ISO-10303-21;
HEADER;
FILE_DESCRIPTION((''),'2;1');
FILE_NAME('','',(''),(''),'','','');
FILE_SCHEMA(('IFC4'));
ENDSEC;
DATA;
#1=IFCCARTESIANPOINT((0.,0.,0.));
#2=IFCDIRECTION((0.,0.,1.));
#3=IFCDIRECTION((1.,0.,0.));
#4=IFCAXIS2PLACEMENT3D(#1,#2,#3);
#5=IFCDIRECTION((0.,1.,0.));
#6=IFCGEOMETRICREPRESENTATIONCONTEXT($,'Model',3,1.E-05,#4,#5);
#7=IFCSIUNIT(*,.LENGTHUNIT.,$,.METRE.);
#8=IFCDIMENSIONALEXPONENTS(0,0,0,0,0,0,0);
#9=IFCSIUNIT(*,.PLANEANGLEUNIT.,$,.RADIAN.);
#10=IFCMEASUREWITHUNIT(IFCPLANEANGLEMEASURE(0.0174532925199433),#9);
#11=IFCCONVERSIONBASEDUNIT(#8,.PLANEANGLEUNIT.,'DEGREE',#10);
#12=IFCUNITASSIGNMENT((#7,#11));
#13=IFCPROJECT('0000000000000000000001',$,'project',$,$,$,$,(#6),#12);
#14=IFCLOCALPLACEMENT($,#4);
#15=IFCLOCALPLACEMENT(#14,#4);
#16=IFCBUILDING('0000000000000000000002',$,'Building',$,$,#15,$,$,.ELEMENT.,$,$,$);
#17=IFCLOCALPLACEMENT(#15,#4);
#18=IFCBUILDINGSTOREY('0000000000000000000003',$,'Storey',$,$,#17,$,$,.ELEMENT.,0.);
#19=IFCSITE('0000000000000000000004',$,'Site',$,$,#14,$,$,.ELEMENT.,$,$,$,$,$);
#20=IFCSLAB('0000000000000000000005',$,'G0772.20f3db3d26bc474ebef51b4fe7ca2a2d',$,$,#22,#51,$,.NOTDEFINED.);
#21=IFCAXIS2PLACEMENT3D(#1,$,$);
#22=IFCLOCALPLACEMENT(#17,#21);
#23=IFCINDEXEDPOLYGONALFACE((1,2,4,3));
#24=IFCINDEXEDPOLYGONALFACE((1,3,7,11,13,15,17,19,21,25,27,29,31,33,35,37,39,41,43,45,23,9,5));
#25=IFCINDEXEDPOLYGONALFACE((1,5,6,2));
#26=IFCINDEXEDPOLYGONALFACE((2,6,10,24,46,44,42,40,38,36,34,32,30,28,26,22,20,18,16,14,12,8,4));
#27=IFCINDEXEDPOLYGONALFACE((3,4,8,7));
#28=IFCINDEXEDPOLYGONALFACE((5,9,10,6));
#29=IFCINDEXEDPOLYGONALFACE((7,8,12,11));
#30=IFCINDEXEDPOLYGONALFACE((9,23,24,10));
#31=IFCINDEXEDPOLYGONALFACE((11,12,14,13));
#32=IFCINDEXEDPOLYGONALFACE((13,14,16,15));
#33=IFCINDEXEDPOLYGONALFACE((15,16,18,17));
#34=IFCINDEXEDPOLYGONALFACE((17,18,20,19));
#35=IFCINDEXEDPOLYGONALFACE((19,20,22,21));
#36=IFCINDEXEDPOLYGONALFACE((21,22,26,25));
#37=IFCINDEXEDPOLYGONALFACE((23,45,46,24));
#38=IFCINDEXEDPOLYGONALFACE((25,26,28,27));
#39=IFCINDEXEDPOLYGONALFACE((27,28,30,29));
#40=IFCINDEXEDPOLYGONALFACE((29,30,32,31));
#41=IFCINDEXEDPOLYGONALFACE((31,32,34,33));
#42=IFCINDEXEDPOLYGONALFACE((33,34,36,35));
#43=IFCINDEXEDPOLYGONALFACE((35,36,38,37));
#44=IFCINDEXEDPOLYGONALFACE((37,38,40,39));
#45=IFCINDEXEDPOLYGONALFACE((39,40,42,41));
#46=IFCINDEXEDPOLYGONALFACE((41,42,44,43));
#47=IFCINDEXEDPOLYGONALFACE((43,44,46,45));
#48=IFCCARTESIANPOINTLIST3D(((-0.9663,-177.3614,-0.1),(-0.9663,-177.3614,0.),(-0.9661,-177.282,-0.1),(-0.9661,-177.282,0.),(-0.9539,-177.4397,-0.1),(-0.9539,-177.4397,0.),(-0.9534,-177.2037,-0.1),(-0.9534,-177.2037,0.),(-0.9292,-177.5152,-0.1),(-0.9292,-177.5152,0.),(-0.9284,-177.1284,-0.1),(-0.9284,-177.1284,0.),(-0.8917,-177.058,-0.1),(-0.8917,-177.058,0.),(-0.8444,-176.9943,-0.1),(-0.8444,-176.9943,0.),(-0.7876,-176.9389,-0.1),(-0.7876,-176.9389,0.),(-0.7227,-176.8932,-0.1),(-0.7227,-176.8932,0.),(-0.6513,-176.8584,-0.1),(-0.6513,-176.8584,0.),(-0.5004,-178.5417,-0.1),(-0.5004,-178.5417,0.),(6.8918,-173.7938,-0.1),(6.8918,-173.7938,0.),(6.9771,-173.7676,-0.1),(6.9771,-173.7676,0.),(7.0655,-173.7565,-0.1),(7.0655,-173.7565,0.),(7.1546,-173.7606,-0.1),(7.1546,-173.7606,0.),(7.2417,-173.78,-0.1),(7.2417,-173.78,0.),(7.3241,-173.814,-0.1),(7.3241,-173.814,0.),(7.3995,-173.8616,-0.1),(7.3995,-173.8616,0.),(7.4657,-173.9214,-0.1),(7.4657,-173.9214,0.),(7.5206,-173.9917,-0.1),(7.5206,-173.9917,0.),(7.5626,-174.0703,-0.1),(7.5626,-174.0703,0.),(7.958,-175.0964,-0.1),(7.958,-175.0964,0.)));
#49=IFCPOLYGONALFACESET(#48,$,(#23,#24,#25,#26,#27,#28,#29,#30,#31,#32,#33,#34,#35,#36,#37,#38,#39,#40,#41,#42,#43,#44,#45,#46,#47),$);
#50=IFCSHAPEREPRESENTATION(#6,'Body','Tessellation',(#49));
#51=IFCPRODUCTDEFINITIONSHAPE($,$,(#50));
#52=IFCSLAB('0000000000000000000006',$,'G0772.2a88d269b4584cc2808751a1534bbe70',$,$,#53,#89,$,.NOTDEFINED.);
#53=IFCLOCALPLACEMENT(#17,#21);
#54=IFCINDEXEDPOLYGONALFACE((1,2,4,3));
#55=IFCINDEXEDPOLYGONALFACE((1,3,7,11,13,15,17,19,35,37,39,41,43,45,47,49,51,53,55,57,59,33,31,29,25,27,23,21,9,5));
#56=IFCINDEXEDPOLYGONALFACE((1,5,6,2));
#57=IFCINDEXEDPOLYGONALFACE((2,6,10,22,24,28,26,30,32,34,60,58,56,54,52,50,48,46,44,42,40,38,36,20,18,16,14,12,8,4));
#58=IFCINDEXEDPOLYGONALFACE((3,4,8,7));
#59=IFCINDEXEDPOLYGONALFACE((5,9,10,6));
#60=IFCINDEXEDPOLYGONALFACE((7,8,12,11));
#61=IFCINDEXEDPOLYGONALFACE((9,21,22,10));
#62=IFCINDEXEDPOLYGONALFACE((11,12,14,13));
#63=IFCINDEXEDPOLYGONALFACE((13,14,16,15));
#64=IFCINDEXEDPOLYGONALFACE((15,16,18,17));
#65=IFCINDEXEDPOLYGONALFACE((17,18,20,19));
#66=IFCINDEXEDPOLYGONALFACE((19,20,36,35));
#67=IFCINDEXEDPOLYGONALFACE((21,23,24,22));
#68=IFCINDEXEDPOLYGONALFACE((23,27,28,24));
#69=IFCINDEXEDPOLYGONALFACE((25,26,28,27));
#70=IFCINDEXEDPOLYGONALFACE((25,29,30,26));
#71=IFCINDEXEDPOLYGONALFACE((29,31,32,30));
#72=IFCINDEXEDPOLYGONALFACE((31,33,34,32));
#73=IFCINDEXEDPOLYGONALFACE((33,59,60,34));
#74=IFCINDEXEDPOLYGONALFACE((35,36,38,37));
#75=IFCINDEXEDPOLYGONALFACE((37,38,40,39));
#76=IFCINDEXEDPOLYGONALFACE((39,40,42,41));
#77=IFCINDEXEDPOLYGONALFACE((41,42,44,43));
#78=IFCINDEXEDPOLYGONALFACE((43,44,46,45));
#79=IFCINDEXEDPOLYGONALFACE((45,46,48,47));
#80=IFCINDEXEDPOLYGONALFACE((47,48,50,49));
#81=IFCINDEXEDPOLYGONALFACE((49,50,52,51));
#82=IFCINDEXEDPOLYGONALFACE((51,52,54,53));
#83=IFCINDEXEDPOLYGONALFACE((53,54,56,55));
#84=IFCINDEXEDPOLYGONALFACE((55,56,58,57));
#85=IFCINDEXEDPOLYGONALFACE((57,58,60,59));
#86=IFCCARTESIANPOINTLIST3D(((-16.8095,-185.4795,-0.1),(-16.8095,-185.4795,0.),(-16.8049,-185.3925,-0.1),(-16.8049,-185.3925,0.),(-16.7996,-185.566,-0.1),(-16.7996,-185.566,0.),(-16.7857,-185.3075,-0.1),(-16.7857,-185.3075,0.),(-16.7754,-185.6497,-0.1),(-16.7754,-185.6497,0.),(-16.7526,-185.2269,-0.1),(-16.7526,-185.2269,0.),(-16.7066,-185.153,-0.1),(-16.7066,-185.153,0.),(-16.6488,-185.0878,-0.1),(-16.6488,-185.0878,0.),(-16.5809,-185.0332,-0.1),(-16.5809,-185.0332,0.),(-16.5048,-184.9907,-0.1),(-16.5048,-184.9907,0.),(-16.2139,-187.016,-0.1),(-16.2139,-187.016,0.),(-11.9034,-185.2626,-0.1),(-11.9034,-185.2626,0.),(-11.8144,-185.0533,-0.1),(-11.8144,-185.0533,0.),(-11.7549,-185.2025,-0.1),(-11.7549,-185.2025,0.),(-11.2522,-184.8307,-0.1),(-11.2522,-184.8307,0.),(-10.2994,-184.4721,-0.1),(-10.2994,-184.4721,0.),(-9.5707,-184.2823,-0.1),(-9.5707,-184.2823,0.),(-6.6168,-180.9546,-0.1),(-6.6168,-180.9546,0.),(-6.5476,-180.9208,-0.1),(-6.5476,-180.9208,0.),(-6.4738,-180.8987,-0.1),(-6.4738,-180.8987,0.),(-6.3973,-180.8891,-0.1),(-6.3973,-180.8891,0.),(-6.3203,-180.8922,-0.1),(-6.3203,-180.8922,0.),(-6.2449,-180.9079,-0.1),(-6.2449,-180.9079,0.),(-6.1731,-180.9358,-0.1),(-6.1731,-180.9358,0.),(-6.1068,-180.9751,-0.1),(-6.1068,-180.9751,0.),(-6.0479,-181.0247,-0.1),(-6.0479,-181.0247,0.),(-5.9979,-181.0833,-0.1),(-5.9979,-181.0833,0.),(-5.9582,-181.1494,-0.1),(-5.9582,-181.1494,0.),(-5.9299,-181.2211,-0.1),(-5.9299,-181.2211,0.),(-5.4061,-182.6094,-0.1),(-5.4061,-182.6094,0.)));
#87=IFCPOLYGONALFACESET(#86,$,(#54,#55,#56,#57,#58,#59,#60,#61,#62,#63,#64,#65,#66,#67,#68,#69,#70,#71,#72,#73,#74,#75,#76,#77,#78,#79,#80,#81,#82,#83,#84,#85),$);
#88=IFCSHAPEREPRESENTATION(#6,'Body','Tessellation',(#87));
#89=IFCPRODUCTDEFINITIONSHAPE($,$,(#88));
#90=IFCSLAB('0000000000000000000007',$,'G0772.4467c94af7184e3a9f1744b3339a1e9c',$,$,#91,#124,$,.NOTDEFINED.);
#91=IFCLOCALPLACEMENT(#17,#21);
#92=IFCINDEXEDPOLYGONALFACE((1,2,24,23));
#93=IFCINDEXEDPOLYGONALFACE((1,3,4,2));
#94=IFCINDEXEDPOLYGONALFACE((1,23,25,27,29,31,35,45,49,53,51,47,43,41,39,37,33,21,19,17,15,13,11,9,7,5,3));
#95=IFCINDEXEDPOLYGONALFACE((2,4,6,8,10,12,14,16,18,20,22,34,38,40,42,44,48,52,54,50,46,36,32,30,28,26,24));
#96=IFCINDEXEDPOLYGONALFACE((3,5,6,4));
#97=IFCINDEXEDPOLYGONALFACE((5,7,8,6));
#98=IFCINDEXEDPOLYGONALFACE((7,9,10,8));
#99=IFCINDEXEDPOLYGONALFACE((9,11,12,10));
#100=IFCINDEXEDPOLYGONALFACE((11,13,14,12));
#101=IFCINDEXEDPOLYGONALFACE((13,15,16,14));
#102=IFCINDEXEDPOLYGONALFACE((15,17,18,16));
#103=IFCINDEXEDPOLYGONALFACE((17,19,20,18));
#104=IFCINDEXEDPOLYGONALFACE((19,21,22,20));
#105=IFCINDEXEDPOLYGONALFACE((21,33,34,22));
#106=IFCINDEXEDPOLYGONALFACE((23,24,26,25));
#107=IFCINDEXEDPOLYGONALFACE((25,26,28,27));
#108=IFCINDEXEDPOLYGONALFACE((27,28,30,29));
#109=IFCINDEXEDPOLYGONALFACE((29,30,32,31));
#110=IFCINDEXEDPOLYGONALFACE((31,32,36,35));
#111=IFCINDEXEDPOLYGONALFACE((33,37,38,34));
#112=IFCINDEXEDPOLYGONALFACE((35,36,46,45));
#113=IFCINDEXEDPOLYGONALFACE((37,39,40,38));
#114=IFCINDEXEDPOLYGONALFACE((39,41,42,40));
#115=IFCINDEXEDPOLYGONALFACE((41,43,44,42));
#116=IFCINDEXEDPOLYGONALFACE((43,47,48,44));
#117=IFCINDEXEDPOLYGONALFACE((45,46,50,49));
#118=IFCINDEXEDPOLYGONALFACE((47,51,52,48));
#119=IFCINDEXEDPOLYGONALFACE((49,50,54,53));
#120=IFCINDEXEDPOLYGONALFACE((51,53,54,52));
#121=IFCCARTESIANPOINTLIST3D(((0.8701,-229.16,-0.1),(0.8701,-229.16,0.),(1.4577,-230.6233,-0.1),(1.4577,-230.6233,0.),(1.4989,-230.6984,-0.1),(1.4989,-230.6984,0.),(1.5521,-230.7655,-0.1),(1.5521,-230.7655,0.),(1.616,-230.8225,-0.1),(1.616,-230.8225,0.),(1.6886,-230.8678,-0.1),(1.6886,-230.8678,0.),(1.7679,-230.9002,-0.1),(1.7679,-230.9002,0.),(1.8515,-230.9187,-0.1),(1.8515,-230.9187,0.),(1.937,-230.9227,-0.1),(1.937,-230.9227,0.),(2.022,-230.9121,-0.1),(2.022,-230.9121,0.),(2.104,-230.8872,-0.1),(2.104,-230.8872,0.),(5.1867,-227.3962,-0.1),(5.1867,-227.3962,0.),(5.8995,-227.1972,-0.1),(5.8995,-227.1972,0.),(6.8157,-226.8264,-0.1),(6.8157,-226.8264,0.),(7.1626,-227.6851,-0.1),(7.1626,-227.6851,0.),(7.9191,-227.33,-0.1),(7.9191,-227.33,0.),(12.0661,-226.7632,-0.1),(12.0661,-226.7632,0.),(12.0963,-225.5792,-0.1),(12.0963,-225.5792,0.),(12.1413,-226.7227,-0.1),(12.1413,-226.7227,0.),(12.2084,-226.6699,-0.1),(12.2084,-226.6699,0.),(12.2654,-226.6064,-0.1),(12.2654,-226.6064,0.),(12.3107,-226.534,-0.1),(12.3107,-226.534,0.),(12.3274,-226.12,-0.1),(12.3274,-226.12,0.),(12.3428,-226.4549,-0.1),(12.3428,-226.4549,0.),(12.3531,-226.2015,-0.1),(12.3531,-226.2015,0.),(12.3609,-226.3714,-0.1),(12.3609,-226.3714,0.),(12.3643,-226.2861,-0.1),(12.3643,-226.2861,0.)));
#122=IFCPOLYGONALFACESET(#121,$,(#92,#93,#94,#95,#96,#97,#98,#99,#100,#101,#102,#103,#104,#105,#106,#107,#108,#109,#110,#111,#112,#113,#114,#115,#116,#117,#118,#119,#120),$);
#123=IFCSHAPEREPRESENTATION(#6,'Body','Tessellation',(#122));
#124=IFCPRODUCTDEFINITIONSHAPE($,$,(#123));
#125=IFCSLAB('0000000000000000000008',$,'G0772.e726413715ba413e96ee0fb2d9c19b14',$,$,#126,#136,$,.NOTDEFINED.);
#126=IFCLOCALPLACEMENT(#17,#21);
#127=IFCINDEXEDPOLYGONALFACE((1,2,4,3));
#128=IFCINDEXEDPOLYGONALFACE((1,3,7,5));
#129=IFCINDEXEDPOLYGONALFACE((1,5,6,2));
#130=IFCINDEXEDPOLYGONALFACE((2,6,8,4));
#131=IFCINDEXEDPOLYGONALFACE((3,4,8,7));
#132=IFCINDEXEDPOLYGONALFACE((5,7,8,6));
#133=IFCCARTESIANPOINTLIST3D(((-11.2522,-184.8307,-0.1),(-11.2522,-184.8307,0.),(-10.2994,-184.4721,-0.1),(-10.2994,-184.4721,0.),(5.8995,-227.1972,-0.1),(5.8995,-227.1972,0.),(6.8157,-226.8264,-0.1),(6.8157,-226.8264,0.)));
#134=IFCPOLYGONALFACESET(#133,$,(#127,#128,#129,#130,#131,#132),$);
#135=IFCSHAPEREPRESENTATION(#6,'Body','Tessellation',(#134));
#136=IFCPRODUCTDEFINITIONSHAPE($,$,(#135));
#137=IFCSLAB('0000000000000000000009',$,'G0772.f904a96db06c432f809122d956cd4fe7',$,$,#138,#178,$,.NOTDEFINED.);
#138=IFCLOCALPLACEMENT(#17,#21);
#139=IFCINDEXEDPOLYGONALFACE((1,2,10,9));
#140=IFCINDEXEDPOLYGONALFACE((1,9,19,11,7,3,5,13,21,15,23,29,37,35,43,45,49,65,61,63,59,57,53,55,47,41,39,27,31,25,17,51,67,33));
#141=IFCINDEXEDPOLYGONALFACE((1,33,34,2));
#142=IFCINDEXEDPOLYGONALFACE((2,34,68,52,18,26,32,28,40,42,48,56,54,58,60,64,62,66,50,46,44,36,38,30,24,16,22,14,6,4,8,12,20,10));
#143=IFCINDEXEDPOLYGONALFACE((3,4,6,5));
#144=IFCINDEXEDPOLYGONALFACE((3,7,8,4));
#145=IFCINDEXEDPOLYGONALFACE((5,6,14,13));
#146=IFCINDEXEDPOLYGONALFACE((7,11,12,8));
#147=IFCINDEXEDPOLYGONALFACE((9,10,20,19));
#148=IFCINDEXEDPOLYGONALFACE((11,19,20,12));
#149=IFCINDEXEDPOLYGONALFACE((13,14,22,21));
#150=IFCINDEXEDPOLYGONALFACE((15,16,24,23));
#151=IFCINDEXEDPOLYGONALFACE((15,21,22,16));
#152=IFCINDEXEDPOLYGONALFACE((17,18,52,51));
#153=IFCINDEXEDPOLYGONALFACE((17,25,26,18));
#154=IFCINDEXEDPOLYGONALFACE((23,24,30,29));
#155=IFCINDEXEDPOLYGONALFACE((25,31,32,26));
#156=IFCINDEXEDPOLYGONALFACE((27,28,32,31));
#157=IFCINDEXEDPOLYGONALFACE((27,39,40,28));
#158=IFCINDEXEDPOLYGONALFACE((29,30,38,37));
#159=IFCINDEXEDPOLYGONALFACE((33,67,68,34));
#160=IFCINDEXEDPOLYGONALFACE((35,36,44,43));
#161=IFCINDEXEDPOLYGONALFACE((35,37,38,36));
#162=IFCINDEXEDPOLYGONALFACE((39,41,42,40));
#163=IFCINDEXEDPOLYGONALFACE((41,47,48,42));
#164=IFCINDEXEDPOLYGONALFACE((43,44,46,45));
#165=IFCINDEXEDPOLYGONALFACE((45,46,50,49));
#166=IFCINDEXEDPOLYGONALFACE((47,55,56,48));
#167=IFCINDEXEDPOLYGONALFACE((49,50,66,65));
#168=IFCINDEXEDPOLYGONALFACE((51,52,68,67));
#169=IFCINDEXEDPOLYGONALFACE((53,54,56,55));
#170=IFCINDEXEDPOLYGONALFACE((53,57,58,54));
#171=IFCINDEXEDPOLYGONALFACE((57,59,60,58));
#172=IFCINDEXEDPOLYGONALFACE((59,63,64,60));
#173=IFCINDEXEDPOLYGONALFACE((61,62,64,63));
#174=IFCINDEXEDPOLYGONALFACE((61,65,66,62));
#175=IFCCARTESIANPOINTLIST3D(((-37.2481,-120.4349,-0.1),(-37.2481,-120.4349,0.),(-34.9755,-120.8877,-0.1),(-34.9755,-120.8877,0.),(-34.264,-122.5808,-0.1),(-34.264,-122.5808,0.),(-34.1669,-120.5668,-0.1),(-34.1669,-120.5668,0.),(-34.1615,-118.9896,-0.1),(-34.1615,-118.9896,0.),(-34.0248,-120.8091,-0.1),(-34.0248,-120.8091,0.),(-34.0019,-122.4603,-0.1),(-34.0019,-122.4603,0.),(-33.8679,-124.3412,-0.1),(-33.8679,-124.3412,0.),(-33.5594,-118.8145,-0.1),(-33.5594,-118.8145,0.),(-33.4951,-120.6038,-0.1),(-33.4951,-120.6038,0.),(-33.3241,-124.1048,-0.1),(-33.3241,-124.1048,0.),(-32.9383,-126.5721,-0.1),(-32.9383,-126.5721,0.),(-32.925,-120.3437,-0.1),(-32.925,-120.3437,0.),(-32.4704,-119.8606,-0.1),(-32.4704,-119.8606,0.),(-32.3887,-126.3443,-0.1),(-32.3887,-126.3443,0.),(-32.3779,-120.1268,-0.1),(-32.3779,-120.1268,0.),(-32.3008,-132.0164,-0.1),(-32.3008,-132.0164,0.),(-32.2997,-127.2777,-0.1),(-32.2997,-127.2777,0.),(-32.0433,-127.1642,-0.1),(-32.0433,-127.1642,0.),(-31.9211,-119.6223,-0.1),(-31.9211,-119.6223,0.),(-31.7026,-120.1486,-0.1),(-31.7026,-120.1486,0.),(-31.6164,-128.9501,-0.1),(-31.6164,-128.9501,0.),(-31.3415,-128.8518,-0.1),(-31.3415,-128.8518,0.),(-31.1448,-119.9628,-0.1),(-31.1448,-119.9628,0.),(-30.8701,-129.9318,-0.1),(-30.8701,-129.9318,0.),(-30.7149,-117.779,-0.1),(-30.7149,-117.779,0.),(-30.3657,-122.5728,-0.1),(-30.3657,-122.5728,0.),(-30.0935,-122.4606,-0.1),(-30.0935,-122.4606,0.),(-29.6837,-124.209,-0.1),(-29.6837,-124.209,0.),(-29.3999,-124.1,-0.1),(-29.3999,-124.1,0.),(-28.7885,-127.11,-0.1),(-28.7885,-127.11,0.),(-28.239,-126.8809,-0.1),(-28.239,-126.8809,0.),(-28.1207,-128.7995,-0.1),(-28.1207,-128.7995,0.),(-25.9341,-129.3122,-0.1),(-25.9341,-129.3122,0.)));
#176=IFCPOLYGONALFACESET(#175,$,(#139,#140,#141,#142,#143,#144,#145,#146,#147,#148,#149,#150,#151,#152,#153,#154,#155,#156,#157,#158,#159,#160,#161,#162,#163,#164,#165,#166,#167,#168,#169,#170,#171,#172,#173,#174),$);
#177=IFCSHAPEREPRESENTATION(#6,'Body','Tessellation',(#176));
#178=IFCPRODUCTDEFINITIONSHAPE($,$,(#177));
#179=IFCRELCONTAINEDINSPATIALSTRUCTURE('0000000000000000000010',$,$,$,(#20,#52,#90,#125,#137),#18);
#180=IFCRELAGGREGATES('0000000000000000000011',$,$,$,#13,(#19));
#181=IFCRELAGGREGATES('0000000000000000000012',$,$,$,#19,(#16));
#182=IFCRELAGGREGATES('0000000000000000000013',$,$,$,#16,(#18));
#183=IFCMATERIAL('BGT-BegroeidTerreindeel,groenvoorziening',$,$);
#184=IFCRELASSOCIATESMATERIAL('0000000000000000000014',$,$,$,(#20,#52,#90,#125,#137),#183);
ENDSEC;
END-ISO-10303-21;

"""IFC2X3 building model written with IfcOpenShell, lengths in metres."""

from ifc_helpers import new_model, entity, si_unit, converted_unit, direction, frame, origin_with_axes, place, context, project, spatial, polyline, outline, extrude, material, element, save


model = new_model("IFC2X3")

# Units and contexts
model_context = context("Model", 3, precision=1e-05, world=origin_with_axes(), true_north=direction((0.0, 1.0, 0.0)))
ifc_project = project(units=[si_unit("LENGTHUNIT", "METRE"), converted_unit("PLANEANGLEUNIT", "DEGREE", entity("IfcPlaneAngleMeasure", 0.0174532925199433), si_unit("PLANEANGLEUNIT", "RADIAN"), dimensions=[0, 0, 0, 0, 0, 0, 0])], contexts=[model_context])

# Site, building, storey
site_placement = place(None, origin_with_axes())
site = spatial("IfcSite", under=ifc_project, at=site_placement, Name="Site", CompositionType="ELEMENT")
building_placement = place(site_placement, origin_with_axes())
building = spatial("IfcBuilding", under=site, at=building_placement, Name="Building", CompositionType="ELEMENT")
storey_placement = place(building_placement, origin_with_axes())
storey = spatial("IfcBuildingStorey", under=building, at=storey_placement, Name="Storey", CompositionType="ELEMENT", Elevation=0.0)

# Slabs
ifc_material_1 = material(Name="BGT-BegroeidTerreindeel,groenvoorziening")
slab_1_placement = place(storey_placement, frame((0.0, 0.0, -0.1), z_axis=(0.0, 0.0, 1.0), x_axis=(1.0, 0.0, 0.0)))
element("IfcSlab", 1, at=slab_1_placement, inside=storey, material=ifc_material_1, Name="G0772.20f3db3d26bc474ebef51b4fe7ca2a2d", PredefinedType="NOTDEFINED", context=model_context, shape_type="SweptSolid", body=[
    extrude(outline(polyline([(7.958, -175.0964), (-0.5004, -178.5417), (-0.9292, -177.5152), (-0.9539, -177.4397), (-0.9663, -177.3614), (-0.9661, -177.282), (-0.9534, -177.2037), (-0.9284, -177.1284), (-0.8917, -177.058), (-0.8444, -176.9943), (-0.7876, -176.9389), (-0.7227, -176.8932), (-0.6513, -176.8584), (6.8918, -173.7938), (6.9771, -173.7676), (7.0655, -173.7565), (7.1546, -173.7606), (7.2417, -173.78), (7.3241, -173.814), (7.3995, -173.8616), (7.4657, -173.9214), (7.5206, -173.9917), (7.5626, -174.0703), (7.958, -175.0964)])), origin_with_axes(), (0.0, 0.0, 1.0), 0.1),
])
slab_2_placement = place(storey_placement, frame((0.0, 0.0, -0.1), z_axis=(0.0, 0.0, 1.0), x_axis=(1.0, 0.0, 0.0)))
element("IfcSlab", 2, at=slab_2_placement, inside=storey, material=ifc_material_1, Name="G0772.2a88d269b4584cc2808751a1534bbe70", PredefinedType="NOTDEFINED", context=model_context, shape_type="SweptSolid", body=[
    extrude(outline(polyline([(-6.5476, -180.9208), (-6.4738, -180.8987), (-6.3973, -180.8891), (-6.3203, -180.8922), (-6.2449, -180.9079), (-6.1731, -180.9358), (-6.1068, -180.9751), (-6.0479, -181.0247), (-5.9979, -181.0833), (-5.9582, -181.1494), (-5.9299, -181.2211), (-5.4061, -182.6094), (-9.5707, -184.2823), (-10.2994, -184.4721), (-11.2522, -184.8307), (-11.8144, -185.0533), (-11.7549, -185.2025), (-11.9034, -185.2626), (-16.2139, -187.016), (-16.7754, -185.6497), (-16.7996, -185.566), (-16.8095, -185.4795), (-16.8049, -185.3925), (-16.7857, -185.3075), (-16.7526, -185.2269), (-16.7066, -185.153), (-16.6488, -185.0878), (-16.5809, -185.0332), (-16.5048, -184.9907), (-6.6168, -180.9546), (-6.5476, -180.9208)])), origin_with_axes(), (0.0, 0.0, 1.0), 0.1),
])
slab_3_placement = place(storey_placement, frame((0.0, 0.0, -0.1), z_axis=(0.0, 0.0, 1.0), x_axis=(1.0, 0.0, 0.0)))
element("IfcSlab", 3, at=slab_3_placement, inside=storey, material=ifc_material_1, Name="G0772.4467c94af7184e3a9f1744b3339a1e9c", PredefinedType="NOTDEFINED", context=model_context, shape_type="SweptSolid", body=[
    extrude(outline(polyline([(12.3531, -226.2015), (12.3643, -226.2861), (12.3609, -226.3714), (12.3428, -226.4549), (12.3107, -226.534), (12.2654, -226.6064), (12.2084, -226.6699), (12.1413, -226.7227), (12.0661, -226.7632), (2.104, -230.8872), (2.022, -230.9121), (1.937, -230.9227), (1.8515, -230.9187), (1.7679, -230.9002), (1.6886, -230.8678), (1.616, -230.8225), (1.5521, -230.7655), (1.4989, -230.6984), (1.4577, -230.6233), (0.8701, -229.16), (5.1867, -227.3962), (5.8995, -227.1972), (6.8157, -226.8264), (7.1626, -227.6851), (7.9191, -227.33), (12.0963, -225.5792), (12.3274, -226.12), (12.3531, -226.2015)])), origin_with_axes(), (0.0, 0.0, 1.0), 0.1),
])
slab_4_placement = place(storey_placement, frame((0.0, 0.0, -0.1), z_axis=(0.0, 0.0, 1.0), x_axis=(1.0, 0.0, 0.0)))
element("IfcSlab", 4, at=slab_4_placement, inside=storey, material=ifc_material_1, Name="G0772.e726413715ba413e96ee0fb2d9c19b14", PredefinedType="NOTDEFINED", context=model_context, shape_type="SweptSolid", body=[
    extrude(outline(polyline([(6.8157, -226.8264), (5.8995, -227.1972), (-11.2522, -184.8307), (-10.2994, -184.4721), (6.8157, -226.8264)])), origin_with_axes(), (0.0, 0.0, 1.0), 0.1),
])
slab_5_placement = place(storey_placement, frame((0.0, 0.0, -0.1), z_axis=(0.0, 0.0, 1.0), x_axis=(1.0, 0.0, 0.0)))
element("IfcSlab", 5, at=slab_5_placement, inside=storey, material=ifc_material_1, Name="G0772.f904a96db06c432f809122d956cd4fe7", PredefinedType="NOTDEFINED", context=model_context, shape_type="SweptSolid", body=[
    extrude(outline(polyline([(-30.7149, -117.779), (-25.9341, -129.3122), (-32.3008, -132.0164), (-37.2481, -120.4349), (-34.1615, -118.9896), (-33.4951, -120.6038), (-34.0248, -120.8091), (-34.1669, -120.5668), (-34.9755, -120.8877), (-34.264, -122.5808), (-34.0019, -122.4603), (-33.3241, -124.1048), (-33.8679, -124.3412), (-32.9383, -126.5721), (-32.3887, -126.3443), (-32.0433, -127.1642), (-32.2997, -127.2777), (-31.6164, -128.9501), (-31.3415, -128.8518), (-30.8701, -129.9318), (-28.1207, -128.7995), (-28.7885, -127.11), (-28.239, -126.8809), (-29.3999, -124.1), (-29.6837, -124.209), (-30.3657, -122.5728), (-30.0935, -122.4606), (-31.1448, -119.9628), (-31.7026, -120.1486), (-31.9211, -119.6223), (-32.4704, -119.8606), (-32.3779, -120.1268), (-32.925, -120.3437), (-33.5594, -118.8145), (-30.7149, -117.779)])), origin_with_axes(), (0.0, 0.0, 1.0), 0.1),
])

save(model, "model.ifc")
